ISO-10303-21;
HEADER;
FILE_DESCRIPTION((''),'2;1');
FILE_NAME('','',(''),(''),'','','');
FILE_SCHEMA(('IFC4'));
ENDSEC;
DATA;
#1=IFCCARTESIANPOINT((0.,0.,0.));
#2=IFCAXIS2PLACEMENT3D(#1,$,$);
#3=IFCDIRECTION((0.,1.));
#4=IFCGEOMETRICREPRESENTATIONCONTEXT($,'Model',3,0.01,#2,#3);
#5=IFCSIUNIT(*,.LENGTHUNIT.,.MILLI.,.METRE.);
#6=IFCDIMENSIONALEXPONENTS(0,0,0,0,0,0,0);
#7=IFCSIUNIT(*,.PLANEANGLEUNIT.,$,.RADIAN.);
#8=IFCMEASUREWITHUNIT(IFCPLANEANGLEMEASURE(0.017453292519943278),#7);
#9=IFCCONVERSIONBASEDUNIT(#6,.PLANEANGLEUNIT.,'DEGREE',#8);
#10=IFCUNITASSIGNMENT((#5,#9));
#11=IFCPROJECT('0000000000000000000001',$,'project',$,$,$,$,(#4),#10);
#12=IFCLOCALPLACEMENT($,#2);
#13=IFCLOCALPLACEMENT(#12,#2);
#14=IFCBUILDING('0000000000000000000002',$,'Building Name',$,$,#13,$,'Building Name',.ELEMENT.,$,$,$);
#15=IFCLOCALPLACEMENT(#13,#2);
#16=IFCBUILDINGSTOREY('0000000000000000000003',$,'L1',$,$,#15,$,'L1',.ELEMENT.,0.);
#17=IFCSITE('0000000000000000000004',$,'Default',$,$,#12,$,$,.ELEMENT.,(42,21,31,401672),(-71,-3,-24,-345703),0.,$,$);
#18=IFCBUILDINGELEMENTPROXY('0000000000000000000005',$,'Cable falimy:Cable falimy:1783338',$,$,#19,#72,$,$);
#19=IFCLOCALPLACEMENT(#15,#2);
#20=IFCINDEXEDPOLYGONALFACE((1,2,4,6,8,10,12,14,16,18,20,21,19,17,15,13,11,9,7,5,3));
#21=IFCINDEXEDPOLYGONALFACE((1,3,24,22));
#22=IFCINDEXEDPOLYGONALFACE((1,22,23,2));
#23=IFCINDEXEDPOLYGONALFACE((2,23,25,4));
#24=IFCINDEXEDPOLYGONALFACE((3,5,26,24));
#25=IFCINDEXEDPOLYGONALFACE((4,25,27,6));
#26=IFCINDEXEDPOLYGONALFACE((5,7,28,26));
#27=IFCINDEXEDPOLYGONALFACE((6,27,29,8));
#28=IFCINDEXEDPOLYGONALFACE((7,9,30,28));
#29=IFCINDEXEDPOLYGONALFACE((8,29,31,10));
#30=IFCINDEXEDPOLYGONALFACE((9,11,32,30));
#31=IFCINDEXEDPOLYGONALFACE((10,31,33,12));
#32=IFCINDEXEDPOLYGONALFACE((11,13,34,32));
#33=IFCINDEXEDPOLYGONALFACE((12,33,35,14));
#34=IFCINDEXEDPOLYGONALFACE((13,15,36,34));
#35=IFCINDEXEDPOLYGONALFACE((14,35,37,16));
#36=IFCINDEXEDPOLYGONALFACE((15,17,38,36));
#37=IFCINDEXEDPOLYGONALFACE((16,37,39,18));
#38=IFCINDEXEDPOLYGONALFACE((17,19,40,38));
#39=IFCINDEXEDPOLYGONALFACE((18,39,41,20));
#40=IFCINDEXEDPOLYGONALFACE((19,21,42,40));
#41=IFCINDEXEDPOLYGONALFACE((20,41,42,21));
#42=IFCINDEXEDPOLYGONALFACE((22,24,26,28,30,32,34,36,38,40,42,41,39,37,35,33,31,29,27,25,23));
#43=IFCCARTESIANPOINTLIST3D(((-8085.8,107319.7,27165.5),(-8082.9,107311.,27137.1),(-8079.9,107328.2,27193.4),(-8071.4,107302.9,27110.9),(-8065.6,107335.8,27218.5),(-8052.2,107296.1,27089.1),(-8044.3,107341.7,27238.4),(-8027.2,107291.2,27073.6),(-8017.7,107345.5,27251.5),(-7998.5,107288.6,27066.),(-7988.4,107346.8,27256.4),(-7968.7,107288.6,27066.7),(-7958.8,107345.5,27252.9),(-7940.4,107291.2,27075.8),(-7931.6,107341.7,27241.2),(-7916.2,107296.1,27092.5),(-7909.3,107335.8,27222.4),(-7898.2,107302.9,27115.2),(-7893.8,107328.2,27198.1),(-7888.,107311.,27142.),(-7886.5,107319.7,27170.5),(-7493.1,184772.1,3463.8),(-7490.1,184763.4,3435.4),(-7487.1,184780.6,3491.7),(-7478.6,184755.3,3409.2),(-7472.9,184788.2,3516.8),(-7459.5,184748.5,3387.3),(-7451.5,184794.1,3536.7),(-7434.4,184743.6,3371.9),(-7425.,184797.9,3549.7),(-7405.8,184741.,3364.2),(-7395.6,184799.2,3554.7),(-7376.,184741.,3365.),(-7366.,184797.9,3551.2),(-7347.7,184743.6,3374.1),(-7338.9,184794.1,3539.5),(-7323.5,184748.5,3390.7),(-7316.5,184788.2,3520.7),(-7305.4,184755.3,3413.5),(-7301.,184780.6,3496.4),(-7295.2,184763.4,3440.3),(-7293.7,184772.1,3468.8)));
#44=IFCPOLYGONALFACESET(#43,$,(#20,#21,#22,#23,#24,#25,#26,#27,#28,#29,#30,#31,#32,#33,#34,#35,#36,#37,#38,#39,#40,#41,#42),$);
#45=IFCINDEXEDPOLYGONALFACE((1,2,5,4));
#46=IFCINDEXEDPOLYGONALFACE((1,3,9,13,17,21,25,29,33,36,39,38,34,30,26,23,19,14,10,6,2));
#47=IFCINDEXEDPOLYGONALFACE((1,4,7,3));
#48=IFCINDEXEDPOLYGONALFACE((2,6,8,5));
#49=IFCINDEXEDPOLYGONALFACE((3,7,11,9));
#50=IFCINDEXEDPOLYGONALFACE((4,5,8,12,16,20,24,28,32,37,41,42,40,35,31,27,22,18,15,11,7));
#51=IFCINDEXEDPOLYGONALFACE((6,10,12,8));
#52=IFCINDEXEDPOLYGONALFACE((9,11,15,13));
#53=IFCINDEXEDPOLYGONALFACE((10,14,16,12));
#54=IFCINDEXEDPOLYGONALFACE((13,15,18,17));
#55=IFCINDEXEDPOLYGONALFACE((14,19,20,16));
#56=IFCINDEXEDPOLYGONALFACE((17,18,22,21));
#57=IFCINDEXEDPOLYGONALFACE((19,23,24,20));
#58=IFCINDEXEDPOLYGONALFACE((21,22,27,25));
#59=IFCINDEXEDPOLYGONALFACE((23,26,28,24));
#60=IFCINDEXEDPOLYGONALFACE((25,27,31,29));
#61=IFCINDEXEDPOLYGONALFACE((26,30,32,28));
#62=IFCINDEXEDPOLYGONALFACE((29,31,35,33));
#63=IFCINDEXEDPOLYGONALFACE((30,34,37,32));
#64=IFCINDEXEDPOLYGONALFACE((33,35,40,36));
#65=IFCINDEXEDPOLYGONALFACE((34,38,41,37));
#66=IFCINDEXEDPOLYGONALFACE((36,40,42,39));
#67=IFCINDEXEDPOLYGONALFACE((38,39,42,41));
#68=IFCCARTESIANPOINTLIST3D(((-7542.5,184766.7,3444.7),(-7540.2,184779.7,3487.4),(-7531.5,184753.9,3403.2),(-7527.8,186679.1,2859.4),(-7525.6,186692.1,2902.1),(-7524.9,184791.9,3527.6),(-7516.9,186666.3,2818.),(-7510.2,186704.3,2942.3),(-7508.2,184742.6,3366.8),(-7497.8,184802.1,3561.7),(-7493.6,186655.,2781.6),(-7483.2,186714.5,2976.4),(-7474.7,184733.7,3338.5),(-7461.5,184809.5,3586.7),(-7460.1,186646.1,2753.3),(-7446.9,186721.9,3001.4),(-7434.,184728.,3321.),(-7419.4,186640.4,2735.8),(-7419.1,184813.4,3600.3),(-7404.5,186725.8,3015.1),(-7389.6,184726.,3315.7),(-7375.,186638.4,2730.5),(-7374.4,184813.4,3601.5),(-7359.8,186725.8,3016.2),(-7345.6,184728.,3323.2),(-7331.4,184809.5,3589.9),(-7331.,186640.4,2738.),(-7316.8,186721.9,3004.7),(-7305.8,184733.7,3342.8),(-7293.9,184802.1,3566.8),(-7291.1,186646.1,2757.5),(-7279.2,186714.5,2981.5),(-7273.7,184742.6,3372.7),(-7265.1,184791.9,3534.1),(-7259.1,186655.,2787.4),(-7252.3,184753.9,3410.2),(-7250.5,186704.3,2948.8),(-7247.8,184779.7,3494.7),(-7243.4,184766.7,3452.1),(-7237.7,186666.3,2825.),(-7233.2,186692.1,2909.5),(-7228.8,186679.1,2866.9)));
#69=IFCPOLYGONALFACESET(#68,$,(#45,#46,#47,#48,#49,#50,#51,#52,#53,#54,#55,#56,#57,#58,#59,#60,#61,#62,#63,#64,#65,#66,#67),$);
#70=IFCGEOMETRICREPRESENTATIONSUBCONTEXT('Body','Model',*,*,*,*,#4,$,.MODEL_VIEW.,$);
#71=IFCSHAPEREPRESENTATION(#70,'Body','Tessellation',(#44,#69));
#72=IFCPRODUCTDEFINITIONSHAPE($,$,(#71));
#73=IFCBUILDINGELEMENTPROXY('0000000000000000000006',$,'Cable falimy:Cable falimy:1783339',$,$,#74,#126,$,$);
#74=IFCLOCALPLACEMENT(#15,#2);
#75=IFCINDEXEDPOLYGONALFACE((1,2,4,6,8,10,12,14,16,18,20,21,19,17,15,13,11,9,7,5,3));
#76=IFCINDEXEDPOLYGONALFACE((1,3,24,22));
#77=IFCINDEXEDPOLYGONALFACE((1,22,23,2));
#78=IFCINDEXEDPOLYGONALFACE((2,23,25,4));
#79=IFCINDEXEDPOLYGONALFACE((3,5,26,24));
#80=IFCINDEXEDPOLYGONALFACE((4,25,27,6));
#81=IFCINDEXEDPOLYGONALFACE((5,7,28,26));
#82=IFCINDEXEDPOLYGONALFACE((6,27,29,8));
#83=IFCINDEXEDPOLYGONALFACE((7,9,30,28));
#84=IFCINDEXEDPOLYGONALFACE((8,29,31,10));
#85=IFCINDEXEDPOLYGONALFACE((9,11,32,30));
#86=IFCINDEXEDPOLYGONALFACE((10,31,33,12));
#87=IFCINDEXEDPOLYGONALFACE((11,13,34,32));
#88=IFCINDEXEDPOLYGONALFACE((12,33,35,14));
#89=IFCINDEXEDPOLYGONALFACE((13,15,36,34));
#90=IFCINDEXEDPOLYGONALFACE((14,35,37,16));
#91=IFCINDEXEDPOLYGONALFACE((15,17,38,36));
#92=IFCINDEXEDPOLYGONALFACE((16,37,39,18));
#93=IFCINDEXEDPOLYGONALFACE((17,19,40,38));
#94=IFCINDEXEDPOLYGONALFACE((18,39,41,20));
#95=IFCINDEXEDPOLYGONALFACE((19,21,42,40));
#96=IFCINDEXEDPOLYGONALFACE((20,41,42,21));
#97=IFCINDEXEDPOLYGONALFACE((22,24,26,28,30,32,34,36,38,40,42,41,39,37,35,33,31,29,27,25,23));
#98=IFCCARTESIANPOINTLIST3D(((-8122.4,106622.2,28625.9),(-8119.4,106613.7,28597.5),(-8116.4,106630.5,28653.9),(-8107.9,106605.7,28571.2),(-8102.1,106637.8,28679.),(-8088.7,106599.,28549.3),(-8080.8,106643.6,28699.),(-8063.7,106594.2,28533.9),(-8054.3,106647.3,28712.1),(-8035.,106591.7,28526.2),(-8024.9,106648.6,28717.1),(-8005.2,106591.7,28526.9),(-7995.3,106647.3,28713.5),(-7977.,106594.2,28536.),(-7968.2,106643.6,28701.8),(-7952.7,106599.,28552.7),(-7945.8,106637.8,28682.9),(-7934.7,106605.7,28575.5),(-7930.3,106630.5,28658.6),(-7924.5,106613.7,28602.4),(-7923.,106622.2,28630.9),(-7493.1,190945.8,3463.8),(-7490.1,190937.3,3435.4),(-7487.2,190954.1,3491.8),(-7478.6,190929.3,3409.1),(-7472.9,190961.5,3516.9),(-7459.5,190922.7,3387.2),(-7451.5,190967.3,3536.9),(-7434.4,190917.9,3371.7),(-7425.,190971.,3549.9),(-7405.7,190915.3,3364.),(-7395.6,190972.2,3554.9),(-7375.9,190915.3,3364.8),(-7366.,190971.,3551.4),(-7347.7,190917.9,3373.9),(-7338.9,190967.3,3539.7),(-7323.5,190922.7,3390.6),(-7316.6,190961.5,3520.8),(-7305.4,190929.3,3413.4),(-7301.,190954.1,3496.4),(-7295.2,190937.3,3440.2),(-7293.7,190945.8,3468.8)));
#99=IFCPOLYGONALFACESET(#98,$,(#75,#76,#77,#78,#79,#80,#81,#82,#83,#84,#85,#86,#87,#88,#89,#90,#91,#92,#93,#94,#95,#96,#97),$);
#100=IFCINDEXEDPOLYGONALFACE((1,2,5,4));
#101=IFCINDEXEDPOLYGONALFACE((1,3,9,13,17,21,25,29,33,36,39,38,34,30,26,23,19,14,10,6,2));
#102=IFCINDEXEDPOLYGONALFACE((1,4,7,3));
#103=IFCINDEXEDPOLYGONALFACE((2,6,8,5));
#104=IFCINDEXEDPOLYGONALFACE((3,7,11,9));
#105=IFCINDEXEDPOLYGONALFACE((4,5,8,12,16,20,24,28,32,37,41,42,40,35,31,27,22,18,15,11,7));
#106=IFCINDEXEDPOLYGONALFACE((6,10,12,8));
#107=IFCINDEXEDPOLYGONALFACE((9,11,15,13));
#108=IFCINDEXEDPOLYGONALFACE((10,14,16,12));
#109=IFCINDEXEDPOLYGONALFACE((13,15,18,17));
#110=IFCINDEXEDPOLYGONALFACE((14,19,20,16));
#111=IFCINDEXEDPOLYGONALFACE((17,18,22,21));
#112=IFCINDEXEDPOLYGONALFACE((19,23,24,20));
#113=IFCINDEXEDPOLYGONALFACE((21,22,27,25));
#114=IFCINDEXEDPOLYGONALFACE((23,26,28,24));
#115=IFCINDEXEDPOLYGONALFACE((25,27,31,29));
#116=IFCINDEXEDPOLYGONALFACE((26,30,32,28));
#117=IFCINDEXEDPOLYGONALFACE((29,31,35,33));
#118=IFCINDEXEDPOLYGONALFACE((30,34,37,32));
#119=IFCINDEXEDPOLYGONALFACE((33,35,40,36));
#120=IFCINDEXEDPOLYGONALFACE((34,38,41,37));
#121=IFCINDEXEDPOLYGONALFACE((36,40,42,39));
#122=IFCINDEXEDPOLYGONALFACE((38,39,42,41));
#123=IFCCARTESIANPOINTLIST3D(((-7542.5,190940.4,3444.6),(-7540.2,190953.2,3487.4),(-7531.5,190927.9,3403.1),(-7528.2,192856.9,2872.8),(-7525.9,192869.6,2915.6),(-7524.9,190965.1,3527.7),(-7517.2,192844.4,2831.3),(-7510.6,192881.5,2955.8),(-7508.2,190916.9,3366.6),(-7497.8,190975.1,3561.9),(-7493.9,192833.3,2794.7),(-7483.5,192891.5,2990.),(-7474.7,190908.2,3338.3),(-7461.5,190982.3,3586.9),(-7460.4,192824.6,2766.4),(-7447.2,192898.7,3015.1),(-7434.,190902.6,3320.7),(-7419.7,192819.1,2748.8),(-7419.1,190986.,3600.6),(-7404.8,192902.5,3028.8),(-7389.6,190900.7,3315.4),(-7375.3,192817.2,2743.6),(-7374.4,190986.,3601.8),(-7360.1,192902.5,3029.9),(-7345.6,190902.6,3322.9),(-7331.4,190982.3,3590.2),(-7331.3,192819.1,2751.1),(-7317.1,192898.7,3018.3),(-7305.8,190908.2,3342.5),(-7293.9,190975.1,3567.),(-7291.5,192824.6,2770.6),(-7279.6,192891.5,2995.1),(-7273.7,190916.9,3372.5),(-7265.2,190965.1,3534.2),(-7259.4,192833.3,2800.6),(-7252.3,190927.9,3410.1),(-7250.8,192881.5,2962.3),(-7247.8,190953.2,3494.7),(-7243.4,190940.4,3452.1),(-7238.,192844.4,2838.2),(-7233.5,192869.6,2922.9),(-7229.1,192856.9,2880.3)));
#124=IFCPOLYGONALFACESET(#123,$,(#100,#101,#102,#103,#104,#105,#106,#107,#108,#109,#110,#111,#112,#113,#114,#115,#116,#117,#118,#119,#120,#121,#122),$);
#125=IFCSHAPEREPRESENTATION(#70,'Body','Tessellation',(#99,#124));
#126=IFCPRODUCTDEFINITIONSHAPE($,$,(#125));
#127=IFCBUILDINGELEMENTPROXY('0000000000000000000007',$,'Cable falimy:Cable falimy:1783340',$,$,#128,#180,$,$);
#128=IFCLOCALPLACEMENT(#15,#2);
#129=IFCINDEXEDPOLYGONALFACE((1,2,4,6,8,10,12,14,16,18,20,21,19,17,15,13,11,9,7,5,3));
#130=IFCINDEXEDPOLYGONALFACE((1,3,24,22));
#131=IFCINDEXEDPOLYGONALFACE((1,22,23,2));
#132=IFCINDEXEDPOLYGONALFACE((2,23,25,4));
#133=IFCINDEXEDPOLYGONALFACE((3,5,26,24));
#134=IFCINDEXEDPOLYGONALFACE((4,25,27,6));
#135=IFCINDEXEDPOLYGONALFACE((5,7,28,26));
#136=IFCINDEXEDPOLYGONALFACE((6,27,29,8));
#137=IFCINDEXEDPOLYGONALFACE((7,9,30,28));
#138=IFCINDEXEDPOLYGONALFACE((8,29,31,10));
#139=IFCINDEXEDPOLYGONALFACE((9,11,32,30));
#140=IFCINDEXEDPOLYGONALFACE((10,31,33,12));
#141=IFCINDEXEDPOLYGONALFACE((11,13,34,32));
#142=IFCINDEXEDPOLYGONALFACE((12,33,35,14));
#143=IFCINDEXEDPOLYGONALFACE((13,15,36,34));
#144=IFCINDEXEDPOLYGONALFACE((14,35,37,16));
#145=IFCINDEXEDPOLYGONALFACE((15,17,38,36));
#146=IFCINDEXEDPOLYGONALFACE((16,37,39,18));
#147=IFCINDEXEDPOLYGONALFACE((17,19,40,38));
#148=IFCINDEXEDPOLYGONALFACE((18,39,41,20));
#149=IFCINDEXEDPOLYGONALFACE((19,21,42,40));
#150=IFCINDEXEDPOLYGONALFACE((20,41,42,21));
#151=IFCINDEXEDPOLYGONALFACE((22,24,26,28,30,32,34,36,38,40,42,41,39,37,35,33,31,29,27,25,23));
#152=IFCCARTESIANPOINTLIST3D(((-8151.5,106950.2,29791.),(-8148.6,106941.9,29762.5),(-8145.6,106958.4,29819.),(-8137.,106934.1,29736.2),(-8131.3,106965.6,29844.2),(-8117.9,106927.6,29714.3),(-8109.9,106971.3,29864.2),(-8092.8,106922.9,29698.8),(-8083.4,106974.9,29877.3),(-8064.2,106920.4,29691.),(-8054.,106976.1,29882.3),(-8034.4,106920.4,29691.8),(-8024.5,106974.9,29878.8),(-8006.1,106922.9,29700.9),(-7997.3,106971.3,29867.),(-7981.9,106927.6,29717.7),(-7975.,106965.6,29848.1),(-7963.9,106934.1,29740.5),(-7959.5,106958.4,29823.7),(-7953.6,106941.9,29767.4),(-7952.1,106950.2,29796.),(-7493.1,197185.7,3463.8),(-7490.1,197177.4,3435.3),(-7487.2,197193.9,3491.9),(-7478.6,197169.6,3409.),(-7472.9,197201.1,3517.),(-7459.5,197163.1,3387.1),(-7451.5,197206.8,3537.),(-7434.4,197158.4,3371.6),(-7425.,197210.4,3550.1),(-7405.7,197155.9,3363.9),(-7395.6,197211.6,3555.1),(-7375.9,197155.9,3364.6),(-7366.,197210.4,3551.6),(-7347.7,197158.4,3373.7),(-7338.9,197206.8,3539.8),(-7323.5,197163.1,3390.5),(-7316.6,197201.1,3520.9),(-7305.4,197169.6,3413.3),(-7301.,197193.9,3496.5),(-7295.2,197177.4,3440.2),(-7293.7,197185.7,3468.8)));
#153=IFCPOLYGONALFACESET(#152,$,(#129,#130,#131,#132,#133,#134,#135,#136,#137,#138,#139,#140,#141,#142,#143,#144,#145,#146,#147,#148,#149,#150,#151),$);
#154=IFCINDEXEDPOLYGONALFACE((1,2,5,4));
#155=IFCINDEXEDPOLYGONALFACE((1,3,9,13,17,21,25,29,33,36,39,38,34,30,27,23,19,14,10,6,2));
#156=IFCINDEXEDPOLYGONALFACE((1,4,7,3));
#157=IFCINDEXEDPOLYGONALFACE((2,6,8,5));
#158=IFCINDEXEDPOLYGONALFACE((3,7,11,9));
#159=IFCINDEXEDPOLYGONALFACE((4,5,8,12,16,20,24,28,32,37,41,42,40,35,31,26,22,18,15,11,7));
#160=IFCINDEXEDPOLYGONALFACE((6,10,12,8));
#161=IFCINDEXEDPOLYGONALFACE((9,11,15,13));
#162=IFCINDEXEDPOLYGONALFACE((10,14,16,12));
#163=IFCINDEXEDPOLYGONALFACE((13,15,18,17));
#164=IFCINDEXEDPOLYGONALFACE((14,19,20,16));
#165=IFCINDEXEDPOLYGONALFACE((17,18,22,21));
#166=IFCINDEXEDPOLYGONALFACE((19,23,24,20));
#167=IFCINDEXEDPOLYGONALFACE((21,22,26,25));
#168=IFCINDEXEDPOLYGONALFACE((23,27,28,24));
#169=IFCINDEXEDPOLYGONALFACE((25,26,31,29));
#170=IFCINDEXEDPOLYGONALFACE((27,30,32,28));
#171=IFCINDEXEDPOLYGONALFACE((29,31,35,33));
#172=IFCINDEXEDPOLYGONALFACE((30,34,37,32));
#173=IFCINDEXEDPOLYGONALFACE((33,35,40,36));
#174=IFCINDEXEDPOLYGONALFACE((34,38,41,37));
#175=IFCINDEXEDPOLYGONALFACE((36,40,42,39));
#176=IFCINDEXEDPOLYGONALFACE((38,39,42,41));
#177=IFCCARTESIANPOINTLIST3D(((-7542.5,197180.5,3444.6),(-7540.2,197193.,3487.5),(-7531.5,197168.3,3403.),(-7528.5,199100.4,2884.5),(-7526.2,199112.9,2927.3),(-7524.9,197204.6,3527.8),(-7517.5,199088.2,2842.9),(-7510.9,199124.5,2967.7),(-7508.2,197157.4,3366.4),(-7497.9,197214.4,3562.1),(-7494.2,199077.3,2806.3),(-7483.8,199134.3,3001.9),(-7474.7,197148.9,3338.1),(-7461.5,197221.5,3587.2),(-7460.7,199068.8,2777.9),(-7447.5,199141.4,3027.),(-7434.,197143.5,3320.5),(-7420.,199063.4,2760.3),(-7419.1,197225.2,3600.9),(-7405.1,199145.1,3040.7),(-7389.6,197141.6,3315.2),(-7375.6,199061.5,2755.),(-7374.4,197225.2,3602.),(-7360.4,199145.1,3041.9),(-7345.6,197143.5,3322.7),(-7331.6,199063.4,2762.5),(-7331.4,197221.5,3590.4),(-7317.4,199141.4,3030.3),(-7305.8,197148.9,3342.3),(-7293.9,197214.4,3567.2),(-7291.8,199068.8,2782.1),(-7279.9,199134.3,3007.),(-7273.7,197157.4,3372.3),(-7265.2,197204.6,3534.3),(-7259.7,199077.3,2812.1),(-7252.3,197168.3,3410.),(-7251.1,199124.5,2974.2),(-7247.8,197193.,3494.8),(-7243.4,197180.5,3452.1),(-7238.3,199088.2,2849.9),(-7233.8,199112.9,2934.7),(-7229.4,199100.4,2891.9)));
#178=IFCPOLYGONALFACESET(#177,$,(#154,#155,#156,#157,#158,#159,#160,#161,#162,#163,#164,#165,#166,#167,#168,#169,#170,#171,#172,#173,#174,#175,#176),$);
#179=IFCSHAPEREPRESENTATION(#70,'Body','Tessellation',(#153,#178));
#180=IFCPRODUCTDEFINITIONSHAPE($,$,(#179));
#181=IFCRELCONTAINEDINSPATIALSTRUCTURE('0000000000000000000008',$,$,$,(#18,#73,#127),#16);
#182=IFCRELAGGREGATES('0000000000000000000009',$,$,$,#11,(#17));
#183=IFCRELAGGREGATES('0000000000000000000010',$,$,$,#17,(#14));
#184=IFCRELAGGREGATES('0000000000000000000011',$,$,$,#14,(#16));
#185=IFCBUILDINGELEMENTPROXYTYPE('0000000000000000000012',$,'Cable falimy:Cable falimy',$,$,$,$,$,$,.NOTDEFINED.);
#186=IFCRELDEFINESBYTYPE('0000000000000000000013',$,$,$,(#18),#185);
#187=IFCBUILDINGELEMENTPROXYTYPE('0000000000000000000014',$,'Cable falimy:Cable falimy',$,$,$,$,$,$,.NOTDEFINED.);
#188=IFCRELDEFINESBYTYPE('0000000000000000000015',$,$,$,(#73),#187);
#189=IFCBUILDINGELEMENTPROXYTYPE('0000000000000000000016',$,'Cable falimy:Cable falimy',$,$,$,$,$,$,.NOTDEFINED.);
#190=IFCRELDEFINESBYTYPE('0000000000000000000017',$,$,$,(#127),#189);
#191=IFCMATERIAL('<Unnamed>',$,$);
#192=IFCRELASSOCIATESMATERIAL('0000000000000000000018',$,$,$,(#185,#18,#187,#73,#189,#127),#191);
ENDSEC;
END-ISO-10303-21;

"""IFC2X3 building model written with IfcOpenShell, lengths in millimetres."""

from ifc_helpers import new_model, entity, si_unit, converted_unit, direction, frame, frame_2d, origin, place, context, subcontext, project, spatial, circle, extrude, source, transform, mapped, material, type_object, type_shapes, element, save


model = new_model("IFC2X3")

# Units and contexts
model_context = context("Model", 3, precision=0.01, world=origin(), true_north=direction((0.0, 1.0)))
body_context = subcontext(model_context, "Body", "Model", "MODEL_VIEW")
ifc_project = project(units=[si_unit("LENGTHUNIT", "METRE", prefix="MILLI"), converted_unit("PLANEANGLEUNIT", "DEGREE", entity("IfcPlaneAngleMeasure", 0.017453292519943278), si_unit("PLANEANGLEUNIT", "RADIAN"), dimensions=[0, 0, 0, 0, 0, 0, 0])], contexts=[model_context])

# Site, building, storey
site_placement = place(None, origin())
site = spatial("IfcSite", under=ifc_project, at=site_placement, Name="Default", CompositionType="ELEMENT", RefLatitude=(42, 21, 31, 401672), RefLongitude=(-71, -3, -24, -345703), RefElevation=0.0)
building_placement = place(site_placement, origin())
building = spatial("IfcBuilding", under=site, at=building_placement, Name="Building Name", LongName="Building Name", CompositionType="ELEMENT")
storey_placement = place(building_placement, origin())
storey = spatial("IfcBuildingStorey", under=building, at=storey_placement, Name="L1", LongName="L1", CompositionType="ELEMENT", Elevation=0.0)

# Shared definitions
ifc_material = material(Name="<Unnamed>")

# Building element proxies
building_element_proxy_type_1 = type_object("IfcBuildingElementProxyType", Name="Cable falimy:Cable falimy", PredefinedType="NOTDEFINED", material=ifc_material)
shared_shape_1 = source(origin(), body_context, "Body", "SweptSolid", [
    extrude(circle(Radius=100.0, at=frame_2d((0.0, 0.0), x_axis=(1.0, 0.0))), frame((0.0, 0.0, 0.0), z_axis=(0.956203, 0.0, 0.292706), x_axis=(-0.292706, 0.0, 0.956203)), (0.0, 0.0, 1.0), 81000.0),
    extrude(circle(Radius=150.0, at=frame_2d((0.0, 0.0), x_axis=(1.0, 0.0))), frame((-1912.4, 0.0, -585.4), z_axis=(0.956203, 0.0, 0.292706), x_axis=(0.292706, 0.0, -0.956203)), (0.0, 0.0, 1.0), 2000.0),
])
type_shapes(building_element_proxy_type_1, [shared_shape_1])
proxy_1_placement = place(storey_placement, frame((-7393.2, 184769.9, 3459.1), z_axis=(-0.025001, 0.0, 0.999687), x_axis=(0.0, -1.0, 0.0)))
element("IfcBuildingElementProxy", 1, at=proxy_1_placement, inside=storey, type_object=building_element_proxy_type_1, material=ifc_material, Name="Cable falimy:Cable falimy:1783338", context=body_context, shape_type="MappedRepresentation", body=[
    mapped(shared_shape_1, transform((0.0, 0.0, 0.0), scale=1.0)),
])
building_element_proxy_type_2 = type_object("IfcBuildingElementProxyType", Name="Cable falimy:Cable falimy", PredefinedType="NOTDEFINED", material=ifc_material)
shared_shape_2 = source(origin(), body_context, "Body", "SweptSolid", [
    extrude(circle(Radius=100.0, at=frame_2d((0.0, 0.0), x_axis=(1.0, 0.0))), frame((0.0, 0.0, 0.0), z_axis=(0.958223, 0.0, 0.286023), x_axis=(-0.286023, 0.0, 0.958223)), (0.0, 0.0, 1.0), 88000.0),
    extrude(circle(Radius=150.0, at=frame_2d((0.0, 0.0), x_axis=(1.0, 0.0))), frame((-1916.4, 0.0, -572.0), z_axis=(0.958223, 0.0, 0.286023), x_axis=(0.286023, 0.0, -0.958223)), (0.0, 0.0, 1.0), 2000.0),
])
type_shapes(building_element_proxy_type_2, [shared_shape_2])
proxy_2_placement = place(storey_placement, frame((-7393.2, 190943.6, 3459.1), z_axis=(-0.025001, 0.0, 0.999687), x_axis=(0.0, -1.0, 0.0)))
element("IfcBuildingElementProxy", 2, at=proxy_2_placement, inside=storey, type_object=building_element_proxy_type_2, material=ifc_material, Name="Cable falimy:Cable falimy:1783339", context=body_context, shape_type="MappedRepresentation", body=[
    mapped(shared_shape_2, transform((0.0, 0.0, 0.0), scale=1.0)),
])
building_element_proxy_type_3 = type_object("IfcBuildingElementProxyType", Name="Cable falimy:Cable falimy", PredefinedType="NOTDEFINED", material=ifc_material)
shared_shape_3 = source(origin(), body_context, "Body", "SweptSolid", [
    extrude(circle(Radius=100.0, at=frame_2d((0.0, 0.0), x_axis=(1.0, 0.0))), frame((0.0, 0.0, 0.0), z_axis=(0.959952, 0.0, 0.280164), x_axis=(-0.280164, 0.0, 0.959952)), (0.0, 0.0, 1.0), 94000.0),
    extrude(circle(Radius=150.0, at=frame_2d((0.0, 0.0), x_axis=(1.0, 0.0))), frame((-1919.9, 0.0, -560.3), z_axis=(0.959952, 0.0, 0.280164), x_axis=(0.280164, 0.0, -0.959952)), (0.0, 0.0, 1.0), 2000.0),
])
type_shapes(building_element_proxy_type_3, [shared_shape_3])
proxy_3_placement = place(storey_placement, frame((-7393.2, 197183.6, 3459.1), z_axis=(-0.025001, 0.0, 0.999687), x_axis=(0.0, -1.0, 0.0)))
element("IfcBuildingElementProxy", 3, at=proxy_3_placement, inside=storey, type_object=building_element_proxy_type_3, material=ifc_material, Name="Cable falimy:Cable falimy:1783340", context=body_context, shape_type="MappedRepresentation", body=[
    mapped(shared_shape_3, transform((0.0, 0.0, 0.0), scale=1.0)),
])

save(model, "model.ifc")
